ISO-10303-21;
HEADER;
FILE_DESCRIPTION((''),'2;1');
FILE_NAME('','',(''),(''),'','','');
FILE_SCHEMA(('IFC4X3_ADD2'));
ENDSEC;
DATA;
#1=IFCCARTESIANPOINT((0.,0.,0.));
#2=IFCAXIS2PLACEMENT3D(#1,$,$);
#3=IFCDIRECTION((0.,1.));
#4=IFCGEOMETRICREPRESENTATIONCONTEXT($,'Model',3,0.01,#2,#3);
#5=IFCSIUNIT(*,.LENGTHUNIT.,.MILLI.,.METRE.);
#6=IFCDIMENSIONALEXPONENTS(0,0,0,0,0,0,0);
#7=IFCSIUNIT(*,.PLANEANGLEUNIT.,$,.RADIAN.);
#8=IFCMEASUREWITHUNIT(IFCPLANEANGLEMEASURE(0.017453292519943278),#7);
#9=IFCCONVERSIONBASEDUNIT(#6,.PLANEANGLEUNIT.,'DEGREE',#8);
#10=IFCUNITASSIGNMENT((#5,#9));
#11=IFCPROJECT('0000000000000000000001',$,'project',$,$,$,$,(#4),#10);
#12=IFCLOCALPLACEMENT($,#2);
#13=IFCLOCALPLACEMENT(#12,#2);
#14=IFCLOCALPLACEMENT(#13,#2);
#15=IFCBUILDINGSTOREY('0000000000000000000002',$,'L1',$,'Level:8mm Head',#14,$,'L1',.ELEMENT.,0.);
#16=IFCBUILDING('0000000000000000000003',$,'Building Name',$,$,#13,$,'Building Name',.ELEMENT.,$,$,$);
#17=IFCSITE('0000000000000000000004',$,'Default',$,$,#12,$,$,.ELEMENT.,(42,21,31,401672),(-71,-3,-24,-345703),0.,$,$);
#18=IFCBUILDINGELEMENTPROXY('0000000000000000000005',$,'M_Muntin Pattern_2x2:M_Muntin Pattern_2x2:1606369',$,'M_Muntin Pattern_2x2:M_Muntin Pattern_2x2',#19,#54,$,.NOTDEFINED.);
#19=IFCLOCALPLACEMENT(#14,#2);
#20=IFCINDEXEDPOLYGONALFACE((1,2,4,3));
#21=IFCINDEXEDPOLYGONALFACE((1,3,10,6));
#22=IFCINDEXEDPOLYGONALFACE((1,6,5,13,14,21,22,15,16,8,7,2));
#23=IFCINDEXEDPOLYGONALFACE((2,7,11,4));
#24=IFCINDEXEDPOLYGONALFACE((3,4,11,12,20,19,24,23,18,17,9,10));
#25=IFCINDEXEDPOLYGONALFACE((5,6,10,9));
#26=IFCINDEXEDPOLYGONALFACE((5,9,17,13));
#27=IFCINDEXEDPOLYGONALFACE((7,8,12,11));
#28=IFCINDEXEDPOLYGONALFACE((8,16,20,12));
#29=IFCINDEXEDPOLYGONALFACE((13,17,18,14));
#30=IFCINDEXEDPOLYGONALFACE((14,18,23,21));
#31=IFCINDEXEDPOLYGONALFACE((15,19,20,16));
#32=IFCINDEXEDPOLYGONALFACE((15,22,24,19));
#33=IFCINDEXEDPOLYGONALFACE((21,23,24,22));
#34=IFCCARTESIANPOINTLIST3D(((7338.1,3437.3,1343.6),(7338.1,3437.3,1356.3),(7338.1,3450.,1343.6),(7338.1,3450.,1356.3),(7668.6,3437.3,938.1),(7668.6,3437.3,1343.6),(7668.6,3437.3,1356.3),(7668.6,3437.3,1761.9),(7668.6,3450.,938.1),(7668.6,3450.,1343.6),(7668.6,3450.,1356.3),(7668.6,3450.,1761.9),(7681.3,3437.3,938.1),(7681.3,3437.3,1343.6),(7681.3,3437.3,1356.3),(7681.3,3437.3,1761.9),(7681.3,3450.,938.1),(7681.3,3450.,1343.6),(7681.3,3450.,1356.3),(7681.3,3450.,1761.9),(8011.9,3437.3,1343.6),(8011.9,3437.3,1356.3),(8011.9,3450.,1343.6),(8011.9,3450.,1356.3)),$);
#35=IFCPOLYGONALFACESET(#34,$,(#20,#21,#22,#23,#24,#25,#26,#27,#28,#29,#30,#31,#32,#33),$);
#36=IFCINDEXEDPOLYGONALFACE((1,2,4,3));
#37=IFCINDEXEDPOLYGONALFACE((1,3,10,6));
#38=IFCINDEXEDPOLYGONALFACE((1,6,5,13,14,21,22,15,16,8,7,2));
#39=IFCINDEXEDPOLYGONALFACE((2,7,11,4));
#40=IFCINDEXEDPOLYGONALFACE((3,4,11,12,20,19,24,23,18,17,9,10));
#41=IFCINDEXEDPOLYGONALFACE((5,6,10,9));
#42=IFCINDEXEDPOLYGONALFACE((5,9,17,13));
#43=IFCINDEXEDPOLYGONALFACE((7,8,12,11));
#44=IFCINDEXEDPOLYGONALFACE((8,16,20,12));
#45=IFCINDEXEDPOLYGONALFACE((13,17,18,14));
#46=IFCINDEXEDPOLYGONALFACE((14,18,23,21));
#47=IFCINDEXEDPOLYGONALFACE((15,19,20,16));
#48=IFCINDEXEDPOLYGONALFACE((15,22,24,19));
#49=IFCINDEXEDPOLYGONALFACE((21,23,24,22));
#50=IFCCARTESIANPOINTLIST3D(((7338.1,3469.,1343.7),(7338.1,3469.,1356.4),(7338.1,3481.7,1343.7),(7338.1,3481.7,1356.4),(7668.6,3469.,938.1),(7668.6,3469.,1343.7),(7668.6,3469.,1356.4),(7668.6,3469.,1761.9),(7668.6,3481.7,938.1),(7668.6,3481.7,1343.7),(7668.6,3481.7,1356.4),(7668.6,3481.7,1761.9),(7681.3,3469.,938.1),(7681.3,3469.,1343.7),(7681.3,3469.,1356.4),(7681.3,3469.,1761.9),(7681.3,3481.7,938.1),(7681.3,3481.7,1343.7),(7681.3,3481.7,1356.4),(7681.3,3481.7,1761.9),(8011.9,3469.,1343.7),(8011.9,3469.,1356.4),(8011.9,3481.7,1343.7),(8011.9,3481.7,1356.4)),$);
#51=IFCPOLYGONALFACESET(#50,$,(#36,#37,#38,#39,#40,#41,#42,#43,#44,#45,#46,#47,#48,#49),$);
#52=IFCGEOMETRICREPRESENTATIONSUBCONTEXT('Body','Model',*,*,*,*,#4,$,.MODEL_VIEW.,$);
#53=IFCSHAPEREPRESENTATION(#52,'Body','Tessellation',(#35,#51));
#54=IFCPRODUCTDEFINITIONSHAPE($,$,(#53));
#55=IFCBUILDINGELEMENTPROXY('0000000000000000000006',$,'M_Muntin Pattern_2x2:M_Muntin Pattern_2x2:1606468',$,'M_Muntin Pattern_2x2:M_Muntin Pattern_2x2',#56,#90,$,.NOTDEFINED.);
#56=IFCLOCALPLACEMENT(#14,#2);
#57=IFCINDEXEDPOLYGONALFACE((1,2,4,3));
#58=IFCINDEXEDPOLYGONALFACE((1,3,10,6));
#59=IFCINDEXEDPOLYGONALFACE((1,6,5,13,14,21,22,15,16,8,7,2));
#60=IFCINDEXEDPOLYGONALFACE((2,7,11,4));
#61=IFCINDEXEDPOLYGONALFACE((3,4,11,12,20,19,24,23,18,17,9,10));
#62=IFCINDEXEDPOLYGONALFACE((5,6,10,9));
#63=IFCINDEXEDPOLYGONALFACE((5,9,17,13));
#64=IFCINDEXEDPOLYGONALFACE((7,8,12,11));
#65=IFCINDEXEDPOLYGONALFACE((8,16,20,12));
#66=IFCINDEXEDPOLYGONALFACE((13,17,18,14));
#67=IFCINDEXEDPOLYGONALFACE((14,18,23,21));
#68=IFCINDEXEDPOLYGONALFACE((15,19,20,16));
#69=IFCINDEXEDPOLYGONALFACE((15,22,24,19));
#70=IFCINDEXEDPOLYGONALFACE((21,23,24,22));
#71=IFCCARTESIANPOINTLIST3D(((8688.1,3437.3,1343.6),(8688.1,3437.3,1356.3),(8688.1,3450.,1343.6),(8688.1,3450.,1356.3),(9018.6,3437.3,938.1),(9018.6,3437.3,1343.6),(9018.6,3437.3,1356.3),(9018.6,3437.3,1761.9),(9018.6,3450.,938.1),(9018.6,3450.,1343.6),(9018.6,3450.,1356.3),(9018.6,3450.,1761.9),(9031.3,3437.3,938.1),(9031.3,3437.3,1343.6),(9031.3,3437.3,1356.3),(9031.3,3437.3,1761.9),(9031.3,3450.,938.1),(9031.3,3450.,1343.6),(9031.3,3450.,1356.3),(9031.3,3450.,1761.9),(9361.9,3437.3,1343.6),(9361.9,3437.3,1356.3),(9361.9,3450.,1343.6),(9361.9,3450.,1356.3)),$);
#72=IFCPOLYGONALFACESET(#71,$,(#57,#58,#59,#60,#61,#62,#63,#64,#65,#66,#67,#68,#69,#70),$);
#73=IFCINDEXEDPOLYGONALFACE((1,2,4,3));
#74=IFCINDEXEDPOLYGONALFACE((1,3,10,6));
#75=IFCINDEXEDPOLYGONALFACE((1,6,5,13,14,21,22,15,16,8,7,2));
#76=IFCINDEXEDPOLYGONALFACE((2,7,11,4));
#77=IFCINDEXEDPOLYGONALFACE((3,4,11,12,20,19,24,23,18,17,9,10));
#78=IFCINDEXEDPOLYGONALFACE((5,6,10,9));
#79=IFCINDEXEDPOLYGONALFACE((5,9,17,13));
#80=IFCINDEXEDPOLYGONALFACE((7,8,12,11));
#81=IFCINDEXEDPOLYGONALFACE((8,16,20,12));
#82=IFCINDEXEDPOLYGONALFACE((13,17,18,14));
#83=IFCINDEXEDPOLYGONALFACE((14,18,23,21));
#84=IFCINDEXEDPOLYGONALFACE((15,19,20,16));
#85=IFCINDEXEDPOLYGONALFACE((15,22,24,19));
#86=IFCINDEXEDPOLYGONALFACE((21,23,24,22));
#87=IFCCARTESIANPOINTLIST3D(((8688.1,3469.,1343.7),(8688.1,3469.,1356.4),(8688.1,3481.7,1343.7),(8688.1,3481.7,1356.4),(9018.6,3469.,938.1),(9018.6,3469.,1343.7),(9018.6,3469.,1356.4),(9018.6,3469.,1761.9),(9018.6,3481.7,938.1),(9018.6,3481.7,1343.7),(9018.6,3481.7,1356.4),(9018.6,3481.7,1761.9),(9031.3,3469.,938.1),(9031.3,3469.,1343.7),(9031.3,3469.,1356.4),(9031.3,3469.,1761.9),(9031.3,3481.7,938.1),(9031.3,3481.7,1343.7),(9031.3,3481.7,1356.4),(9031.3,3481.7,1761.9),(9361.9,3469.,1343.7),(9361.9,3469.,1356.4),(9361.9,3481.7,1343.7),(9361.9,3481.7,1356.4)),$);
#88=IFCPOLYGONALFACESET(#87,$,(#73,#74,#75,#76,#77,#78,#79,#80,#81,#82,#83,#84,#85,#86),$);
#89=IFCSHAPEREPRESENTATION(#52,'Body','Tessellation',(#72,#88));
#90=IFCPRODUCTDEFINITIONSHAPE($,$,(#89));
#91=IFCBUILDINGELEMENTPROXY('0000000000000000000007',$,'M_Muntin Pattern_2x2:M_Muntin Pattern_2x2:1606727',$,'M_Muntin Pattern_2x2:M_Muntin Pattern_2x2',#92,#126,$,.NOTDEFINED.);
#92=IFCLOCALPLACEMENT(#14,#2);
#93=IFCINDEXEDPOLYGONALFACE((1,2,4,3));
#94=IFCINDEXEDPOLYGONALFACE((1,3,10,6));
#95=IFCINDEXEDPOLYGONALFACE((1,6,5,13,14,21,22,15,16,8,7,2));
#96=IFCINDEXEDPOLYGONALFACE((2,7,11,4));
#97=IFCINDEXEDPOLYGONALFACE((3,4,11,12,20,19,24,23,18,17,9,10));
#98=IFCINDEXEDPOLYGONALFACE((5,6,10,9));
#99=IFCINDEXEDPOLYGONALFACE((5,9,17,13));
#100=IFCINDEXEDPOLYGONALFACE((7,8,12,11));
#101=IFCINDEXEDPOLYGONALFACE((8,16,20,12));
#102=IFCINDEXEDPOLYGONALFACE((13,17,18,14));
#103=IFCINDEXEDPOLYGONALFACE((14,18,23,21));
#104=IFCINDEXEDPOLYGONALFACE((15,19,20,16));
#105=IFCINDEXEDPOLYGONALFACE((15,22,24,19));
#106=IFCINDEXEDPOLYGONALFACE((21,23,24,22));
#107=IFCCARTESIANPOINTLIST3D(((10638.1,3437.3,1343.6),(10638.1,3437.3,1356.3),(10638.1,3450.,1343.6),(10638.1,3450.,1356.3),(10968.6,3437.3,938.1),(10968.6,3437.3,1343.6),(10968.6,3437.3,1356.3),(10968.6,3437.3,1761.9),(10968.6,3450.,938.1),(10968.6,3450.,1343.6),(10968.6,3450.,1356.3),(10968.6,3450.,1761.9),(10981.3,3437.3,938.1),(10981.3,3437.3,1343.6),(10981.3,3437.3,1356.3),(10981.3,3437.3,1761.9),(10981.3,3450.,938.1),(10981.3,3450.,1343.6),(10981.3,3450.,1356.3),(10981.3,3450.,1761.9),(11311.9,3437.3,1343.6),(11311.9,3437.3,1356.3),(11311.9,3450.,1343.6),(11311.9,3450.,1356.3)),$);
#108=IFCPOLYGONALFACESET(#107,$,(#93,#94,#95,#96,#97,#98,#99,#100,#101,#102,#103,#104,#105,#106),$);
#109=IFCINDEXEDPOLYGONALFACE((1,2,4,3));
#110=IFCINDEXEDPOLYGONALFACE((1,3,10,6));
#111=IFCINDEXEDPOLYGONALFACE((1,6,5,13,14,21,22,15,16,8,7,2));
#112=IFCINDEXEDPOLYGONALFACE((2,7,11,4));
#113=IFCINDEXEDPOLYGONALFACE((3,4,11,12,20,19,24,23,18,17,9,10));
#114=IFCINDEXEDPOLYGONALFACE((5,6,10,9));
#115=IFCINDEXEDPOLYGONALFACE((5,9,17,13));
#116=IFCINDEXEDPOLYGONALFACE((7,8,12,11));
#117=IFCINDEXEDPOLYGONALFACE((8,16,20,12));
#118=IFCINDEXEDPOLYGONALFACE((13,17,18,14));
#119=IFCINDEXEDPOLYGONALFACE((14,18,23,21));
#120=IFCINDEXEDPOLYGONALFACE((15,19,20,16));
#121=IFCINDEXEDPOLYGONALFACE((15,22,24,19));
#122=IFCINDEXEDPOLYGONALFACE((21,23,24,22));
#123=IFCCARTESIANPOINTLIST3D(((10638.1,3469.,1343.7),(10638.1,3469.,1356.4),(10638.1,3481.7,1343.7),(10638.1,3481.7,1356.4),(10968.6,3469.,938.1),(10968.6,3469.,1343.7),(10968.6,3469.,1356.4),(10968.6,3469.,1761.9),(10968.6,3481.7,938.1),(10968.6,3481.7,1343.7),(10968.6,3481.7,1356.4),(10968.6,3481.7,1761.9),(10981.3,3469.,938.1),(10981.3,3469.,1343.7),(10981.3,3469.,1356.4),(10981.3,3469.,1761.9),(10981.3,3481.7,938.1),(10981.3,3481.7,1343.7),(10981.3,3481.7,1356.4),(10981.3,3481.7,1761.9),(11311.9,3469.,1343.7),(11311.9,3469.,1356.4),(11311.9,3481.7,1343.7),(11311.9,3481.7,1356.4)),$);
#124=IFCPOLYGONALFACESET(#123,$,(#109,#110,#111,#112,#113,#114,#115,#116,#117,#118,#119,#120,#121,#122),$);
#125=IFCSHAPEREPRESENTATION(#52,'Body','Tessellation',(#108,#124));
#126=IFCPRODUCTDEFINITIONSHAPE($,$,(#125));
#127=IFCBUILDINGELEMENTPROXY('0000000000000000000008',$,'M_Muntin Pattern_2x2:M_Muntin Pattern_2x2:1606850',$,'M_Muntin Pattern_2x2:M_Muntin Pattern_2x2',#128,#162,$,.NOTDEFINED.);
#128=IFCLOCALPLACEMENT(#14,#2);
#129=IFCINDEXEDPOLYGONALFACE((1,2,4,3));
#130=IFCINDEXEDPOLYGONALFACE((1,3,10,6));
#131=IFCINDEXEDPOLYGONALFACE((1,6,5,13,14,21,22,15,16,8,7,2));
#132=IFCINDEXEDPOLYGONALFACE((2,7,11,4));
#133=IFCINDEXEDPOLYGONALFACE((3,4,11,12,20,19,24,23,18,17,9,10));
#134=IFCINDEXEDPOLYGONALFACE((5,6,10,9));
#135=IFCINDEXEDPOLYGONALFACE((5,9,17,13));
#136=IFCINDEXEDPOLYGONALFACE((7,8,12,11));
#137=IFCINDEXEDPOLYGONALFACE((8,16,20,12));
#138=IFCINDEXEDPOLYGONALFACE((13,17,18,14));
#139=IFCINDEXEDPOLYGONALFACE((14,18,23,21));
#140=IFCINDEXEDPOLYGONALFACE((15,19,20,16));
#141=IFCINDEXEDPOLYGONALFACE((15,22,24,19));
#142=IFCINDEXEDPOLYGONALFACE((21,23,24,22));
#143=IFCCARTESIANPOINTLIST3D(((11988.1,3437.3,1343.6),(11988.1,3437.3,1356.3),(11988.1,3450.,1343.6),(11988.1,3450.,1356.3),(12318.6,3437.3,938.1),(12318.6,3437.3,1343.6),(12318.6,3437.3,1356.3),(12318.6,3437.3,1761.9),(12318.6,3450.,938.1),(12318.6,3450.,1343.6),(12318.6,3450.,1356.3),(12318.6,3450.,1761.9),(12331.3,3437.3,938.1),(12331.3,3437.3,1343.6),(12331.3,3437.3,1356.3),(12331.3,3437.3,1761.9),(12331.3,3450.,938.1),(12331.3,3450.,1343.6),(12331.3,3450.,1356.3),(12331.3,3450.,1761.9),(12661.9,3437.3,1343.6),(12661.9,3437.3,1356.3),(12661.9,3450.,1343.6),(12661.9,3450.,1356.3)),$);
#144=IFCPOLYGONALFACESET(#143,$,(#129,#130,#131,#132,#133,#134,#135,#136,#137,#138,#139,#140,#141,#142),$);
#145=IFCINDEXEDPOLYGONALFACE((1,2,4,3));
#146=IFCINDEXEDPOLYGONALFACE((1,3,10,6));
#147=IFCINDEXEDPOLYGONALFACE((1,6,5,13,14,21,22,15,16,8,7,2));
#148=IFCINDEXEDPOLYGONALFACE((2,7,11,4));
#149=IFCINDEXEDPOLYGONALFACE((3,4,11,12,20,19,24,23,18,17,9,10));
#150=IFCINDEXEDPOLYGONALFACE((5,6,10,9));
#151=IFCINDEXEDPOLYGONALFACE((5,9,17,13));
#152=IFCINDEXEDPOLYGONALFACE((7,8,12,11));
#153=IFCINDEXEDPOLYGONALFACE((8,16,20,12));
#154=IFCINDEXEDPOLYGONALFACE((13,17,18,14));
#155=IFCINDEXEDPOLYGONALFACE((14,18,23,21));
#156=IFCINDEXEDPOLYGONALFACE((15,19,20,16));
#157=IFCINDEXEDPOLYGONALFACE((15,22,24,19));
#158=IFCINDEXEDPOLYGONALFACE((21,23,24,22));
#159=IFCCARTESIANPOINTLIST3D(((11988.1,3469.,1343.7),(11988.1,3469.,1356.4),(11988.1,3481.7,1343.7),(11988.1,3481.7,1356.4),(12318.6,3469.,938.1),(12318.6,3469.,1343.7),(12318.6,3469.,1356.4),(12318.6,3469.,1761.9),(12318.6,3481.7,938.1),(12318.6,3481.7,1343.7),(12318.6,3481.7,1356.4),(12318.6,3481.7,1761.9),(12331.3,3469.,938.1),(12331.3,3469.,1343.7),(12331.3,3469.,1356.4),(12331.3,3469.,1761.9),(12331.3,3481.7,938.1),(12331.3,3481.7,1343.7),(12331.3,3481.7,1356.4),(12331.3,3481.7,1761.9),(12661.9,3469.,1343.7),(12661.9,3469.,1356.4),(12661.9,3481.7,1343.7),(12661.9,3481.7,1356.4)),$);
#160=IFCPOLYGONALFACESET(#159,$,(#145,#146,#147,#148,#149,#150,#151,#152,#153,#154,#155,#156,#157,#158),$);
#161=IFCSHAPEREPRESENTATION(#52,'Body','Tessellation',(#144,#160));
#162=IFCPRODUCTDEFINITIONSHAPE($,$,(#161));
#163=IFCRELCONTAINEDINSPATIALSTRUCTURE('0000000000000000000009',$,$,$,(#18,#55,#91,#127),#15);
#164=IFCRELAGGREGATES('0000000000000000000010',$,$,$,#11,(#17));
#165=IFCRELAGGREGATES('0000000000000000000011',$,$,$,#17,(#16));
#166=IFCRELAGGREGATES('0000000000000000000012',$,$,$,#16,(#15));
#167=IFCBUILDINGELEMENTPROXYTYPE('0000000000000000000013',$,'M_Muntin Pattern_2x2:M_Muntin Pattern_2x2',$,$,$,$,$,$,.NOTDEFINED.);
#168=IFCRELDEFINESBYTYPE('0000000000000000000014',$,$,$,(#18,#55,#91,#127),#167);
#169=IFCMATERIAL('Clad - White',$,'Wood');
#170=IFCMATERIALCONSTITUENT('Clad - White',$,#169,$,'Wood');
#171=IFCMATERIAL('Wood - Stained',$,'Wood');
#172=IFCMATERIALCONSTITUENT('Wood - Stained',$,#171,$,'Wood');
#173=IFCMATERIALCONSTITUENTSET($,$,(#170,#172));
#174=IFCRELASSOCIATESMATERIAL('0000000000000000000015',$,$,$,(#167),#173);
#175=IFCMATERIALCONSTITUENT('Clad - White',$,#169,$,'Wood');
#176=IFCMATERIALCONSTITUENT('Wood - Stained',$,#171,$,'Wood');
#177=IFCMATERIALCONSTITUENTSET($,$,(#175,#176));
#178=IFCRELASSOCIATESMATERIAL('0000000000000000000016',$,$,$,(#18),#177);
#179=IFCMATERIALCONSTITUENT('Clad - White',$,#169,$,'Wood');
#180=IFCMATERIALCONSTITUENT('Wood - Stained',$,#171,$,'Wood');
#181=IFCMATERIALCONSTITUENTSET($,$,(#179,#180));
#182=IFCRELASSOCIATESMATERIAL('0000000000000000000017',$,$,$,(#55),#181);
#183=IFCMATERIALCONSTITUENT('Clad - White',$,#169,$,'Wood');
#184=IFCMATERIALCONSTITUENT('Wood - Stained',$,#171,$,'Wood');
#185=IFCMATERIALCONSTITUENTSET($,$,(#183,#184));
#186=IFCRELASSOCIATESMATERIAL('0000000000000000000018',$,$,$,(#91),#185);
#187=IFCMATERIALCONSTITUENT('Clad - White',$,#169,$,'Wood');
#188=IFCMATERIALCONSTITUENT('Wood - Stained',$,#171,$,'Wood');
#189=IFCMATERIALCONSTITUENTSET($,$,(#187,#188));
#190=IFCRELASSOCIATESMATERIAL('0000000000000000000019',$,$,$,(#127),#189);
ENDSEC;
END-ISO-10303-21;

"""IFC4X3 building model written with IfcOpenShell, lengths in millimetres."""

from ifc_helpers import new_model, entity, si_unit, converted_unit, direction, frame, origin, place, context, subcontext, project, spatial, polyline, outline, extrude, source, transform, mapped, material, constituent, constituent_set, type_object, type_shapes, element, save


model = new_model("IFC4X3")

# Units and contexts
model_context = context("Model", 3, precision=0.01, world=origin(), true_north=direction((0.0, 1.0)))
body_context = subcontext(model_context, "Body", "Model", "MODEL_VIEW")
ifc_project = project(units=[si_unit("LENGTHUNIT", "METRE", prefix="MILLI"), converted_unit("PLANEANGLEUNIT", "DEGREE", entity("IfcPlaneAngleMeasure", 0.017453292519943278), si_unit("PLANEANGLEUNIT", "RADIAN"), dimensions=[0, 0, 0, 0, 0, 0, 0])], contexts=[model_context])

# Site, building, storey
site_placement = place(None, origin())
site = spatial("IfcSite", under=ifc_project, at=site_placement, Name="Default", CompositionType="ELEMENT", RefLatitude=(42, 21, 31, 401672), RefLongitude=(-71, -3, -24, -345703), RefElevation=0.0)
building_placement = place(site_placement, origin())
building = spatial("IfcBuilding", under=site, at=building_placement, Name="Building Name", LongName="Building Name", CompositionType="ELEMENT")
storey_placement = place(building_placement, origin())
storey = spatial("IfcBuildingStorey", under=building, at=storey_placement, Name="L1", ObjectType="Level:8mm Head", LongName="L1", CompositionType="ELEMENT", Elevation=0.0)

# Building element proxies
ifc_material_1 = material(Name="Clad - White", Category="Wood")
ifc_material_2 = material(Name="Wood - Stained", Category="Wood")
ifc_constituent_1 = constituent(ifc_material_1, Name="Clad - White", Category="Wood")
ifc_constituent_2 = constituent(ifc_material_2, Name="Wood - Stained", Category="Wood")
ifc_constituent_set_1 = constituent_set(constituents=[ifc_constituent_1, ifc_constituent_2])
building_element_proxy_type_1 = type_object("IfcBuildingElementProxyType", Name="M_Muntin Pattern_2x2:M_Muntin Pattern_2x2", PredefinedType="NOTDEFINED", material=ifc_constituent_set_1)
shared_shape_1 = source(origin(), body_context, "Body", "SweptSolid", [
    extrude(outline(polyline([(6.4, -6.4), (411.9, -6.4), (411.9, 6.3), (6.4, 6.3), (6.4, 336.9), (-6.3, 336.9), (-6.3, 6.3), (-411.9, 6.3), (-411.9, -6.4), (-6.3, -6.4), (-6.3, -336.9), (6.4, -336.9), (6.4, -6.4)])), frame((0.0, -22.2, 411.9), z_axis=(0.0, 1.0, 0.0), x_axis=(0.0, 0.0, 1.0)), (0.0, 0.0, 1.0), 12.7),
    extrude(outline(polyline([(6.4, -6.4), (411.9, -6.4), (411.9, 6.3), (6.4, 6.3), (6.4, 336.9), (-6.3, 336.9), (-6.3, 6.3), (-411.9, 6.3), (-411.9, -6.4), (-6.3, -6.4), (-6.3, -336.9), (6.4, -336.9), (6.4, -6.4)])), frame((0.0, 9.5, 411.9), z_axis=(0.0, 1.0, 0.0), x_axis=(0.0, 0.0, 1.0)), (0.0, 0.0, 1.0), 12.7),
])
type_shapes(building_element_proxy_type_1, [shared_shape_1])
ifc_constituent_3 = constituent(ifc_material_1, Name="Clad - White", Category="Wood")
ifc_constituent_4 = constituent(ifc_material_2, Name="Wood - Stained", Category="Wood")
ifc_constituent_set_2 = constituent_set(constituents=[ifc_constituent_3, ifc_constituent_4])
proxy_1_placement = place(storey_placement, frame((7675.0, 3459.5, 938.1)))
element("IfcBuildingElementProxy", 1, at=proxy_1_placement, inside=storey, type_object=building_element_proxy_type_1, material=ifc_constituent_set_2, Name="M_Muntin Pattern_2x2:M_Muntin Pattern_2x2:1606369", ObjectType="M_Muntin Pattern_2x2:M_Muntin Pattern_2x2", PredefinedType="NOTDEFINED", context=body_context, shape_type="MappedRepresentation", body=[
    mapped(shared_shape_1, transform((0.0, 0.0, 0.0), scale=1.0)),
])
ifc_constituent_5 = constituent(ifc_material_1, Name="Clad - White", Category="Wood")
ifc_constituent_6 = constituent(ifc_material_2, Name="Wood - Stained", Category="Wood")
ifc_constituent_set_3 = constituent_set(constituents=[ifc_constituent_5, ifc_constituent_6])
proxy_2_placement = place(storey_placement, frame((9025.0, 3459.5, 938.1)))
element("IfcBuildingElementProxy", 2, at=proxy_2_placement, inside=storey, type_object=building_element_proxy_type_1, material=ifc_constituent_set_3, Name="M_Muntin Pattern_2x2:M_Muntin Pattern_2x2:1606468", ObjectType="M_Muntin Pattern_2x2:M_Muntin Pattern_2x2", PredefinedType="NOTDEFINED", context=body_context, shape_type="MappedRepresentation", body=[
    mapped(shared_shape_1, transform((0.0, 0.0, 0.0), scale=1.0)),
])
ifc_constituent_7 = constituent(ifc_material_1, Name="Clad - White", Category="Wood")
ifc_constituent_8 = constituent(ifc_material_2, Name="Wood - Stained", Category="Wood")
ifc_constituent_set_4 = constituent_set(constituents=[ifc_constituent_7, ifc_constituent_8])
proxy_3_placement = place(storey_placement, frame((10975.0, 3459.5, 938.1)))
element("IfcBuildingElementProxy", 3, at=proxy_3_placement, inside=storey, type_object=building_element_proxy_type_1, material=ifc_constituent_set_4, Name="M_Muntin Pattern_2x2:M_Muntin Pattern_2x2:1606727", ObjectType="M_Muntin Pattern_2x2:M_Muntin Pattern_2x2", PredefinedType="NOTDEFINED", context=body_context, shape_type="MappedRepresentation", body=[
    mapped(shared_shape_1, transform((0.0, 0.0, 0.0), scale=1.0)),
])
ifc_constituent_9 = constituent(ifc_material_1, Name="Clad - White", Category="Wood")
ifc_constituent_10 = constituent(ifc_material_2, Name="Wood - Stained", Category="Wood")
ifc_constituent_set_5 = constituent_set(constituents=[ifc_constituent_9, ifc_constituent_10])
proxy_4_placement = place(storey_placement, frame((12325.0, 3459.5, 938.1)))
element("IfcBuildingElementProxy", 4, at=proxy_4_placement, inside=storey, type_object=building_element_proxy_type_1, material=ifc_constituent_set_5, Name="M_Muntin Pattern_2x2:M_Muntin Pattern_2x2:1606850", ObjectType="M_Muntin Pattern_2x2:M_Muntin Pattern_2x2", PredefinedType="NOTDEFINED", context=body_context, shape_type="MappedRepresentation", body=[
    mapped(shared_shape_1, transform((0.0, 0.0, 0.0), scale=1.0)),
])

save(model, "model.ifc")
